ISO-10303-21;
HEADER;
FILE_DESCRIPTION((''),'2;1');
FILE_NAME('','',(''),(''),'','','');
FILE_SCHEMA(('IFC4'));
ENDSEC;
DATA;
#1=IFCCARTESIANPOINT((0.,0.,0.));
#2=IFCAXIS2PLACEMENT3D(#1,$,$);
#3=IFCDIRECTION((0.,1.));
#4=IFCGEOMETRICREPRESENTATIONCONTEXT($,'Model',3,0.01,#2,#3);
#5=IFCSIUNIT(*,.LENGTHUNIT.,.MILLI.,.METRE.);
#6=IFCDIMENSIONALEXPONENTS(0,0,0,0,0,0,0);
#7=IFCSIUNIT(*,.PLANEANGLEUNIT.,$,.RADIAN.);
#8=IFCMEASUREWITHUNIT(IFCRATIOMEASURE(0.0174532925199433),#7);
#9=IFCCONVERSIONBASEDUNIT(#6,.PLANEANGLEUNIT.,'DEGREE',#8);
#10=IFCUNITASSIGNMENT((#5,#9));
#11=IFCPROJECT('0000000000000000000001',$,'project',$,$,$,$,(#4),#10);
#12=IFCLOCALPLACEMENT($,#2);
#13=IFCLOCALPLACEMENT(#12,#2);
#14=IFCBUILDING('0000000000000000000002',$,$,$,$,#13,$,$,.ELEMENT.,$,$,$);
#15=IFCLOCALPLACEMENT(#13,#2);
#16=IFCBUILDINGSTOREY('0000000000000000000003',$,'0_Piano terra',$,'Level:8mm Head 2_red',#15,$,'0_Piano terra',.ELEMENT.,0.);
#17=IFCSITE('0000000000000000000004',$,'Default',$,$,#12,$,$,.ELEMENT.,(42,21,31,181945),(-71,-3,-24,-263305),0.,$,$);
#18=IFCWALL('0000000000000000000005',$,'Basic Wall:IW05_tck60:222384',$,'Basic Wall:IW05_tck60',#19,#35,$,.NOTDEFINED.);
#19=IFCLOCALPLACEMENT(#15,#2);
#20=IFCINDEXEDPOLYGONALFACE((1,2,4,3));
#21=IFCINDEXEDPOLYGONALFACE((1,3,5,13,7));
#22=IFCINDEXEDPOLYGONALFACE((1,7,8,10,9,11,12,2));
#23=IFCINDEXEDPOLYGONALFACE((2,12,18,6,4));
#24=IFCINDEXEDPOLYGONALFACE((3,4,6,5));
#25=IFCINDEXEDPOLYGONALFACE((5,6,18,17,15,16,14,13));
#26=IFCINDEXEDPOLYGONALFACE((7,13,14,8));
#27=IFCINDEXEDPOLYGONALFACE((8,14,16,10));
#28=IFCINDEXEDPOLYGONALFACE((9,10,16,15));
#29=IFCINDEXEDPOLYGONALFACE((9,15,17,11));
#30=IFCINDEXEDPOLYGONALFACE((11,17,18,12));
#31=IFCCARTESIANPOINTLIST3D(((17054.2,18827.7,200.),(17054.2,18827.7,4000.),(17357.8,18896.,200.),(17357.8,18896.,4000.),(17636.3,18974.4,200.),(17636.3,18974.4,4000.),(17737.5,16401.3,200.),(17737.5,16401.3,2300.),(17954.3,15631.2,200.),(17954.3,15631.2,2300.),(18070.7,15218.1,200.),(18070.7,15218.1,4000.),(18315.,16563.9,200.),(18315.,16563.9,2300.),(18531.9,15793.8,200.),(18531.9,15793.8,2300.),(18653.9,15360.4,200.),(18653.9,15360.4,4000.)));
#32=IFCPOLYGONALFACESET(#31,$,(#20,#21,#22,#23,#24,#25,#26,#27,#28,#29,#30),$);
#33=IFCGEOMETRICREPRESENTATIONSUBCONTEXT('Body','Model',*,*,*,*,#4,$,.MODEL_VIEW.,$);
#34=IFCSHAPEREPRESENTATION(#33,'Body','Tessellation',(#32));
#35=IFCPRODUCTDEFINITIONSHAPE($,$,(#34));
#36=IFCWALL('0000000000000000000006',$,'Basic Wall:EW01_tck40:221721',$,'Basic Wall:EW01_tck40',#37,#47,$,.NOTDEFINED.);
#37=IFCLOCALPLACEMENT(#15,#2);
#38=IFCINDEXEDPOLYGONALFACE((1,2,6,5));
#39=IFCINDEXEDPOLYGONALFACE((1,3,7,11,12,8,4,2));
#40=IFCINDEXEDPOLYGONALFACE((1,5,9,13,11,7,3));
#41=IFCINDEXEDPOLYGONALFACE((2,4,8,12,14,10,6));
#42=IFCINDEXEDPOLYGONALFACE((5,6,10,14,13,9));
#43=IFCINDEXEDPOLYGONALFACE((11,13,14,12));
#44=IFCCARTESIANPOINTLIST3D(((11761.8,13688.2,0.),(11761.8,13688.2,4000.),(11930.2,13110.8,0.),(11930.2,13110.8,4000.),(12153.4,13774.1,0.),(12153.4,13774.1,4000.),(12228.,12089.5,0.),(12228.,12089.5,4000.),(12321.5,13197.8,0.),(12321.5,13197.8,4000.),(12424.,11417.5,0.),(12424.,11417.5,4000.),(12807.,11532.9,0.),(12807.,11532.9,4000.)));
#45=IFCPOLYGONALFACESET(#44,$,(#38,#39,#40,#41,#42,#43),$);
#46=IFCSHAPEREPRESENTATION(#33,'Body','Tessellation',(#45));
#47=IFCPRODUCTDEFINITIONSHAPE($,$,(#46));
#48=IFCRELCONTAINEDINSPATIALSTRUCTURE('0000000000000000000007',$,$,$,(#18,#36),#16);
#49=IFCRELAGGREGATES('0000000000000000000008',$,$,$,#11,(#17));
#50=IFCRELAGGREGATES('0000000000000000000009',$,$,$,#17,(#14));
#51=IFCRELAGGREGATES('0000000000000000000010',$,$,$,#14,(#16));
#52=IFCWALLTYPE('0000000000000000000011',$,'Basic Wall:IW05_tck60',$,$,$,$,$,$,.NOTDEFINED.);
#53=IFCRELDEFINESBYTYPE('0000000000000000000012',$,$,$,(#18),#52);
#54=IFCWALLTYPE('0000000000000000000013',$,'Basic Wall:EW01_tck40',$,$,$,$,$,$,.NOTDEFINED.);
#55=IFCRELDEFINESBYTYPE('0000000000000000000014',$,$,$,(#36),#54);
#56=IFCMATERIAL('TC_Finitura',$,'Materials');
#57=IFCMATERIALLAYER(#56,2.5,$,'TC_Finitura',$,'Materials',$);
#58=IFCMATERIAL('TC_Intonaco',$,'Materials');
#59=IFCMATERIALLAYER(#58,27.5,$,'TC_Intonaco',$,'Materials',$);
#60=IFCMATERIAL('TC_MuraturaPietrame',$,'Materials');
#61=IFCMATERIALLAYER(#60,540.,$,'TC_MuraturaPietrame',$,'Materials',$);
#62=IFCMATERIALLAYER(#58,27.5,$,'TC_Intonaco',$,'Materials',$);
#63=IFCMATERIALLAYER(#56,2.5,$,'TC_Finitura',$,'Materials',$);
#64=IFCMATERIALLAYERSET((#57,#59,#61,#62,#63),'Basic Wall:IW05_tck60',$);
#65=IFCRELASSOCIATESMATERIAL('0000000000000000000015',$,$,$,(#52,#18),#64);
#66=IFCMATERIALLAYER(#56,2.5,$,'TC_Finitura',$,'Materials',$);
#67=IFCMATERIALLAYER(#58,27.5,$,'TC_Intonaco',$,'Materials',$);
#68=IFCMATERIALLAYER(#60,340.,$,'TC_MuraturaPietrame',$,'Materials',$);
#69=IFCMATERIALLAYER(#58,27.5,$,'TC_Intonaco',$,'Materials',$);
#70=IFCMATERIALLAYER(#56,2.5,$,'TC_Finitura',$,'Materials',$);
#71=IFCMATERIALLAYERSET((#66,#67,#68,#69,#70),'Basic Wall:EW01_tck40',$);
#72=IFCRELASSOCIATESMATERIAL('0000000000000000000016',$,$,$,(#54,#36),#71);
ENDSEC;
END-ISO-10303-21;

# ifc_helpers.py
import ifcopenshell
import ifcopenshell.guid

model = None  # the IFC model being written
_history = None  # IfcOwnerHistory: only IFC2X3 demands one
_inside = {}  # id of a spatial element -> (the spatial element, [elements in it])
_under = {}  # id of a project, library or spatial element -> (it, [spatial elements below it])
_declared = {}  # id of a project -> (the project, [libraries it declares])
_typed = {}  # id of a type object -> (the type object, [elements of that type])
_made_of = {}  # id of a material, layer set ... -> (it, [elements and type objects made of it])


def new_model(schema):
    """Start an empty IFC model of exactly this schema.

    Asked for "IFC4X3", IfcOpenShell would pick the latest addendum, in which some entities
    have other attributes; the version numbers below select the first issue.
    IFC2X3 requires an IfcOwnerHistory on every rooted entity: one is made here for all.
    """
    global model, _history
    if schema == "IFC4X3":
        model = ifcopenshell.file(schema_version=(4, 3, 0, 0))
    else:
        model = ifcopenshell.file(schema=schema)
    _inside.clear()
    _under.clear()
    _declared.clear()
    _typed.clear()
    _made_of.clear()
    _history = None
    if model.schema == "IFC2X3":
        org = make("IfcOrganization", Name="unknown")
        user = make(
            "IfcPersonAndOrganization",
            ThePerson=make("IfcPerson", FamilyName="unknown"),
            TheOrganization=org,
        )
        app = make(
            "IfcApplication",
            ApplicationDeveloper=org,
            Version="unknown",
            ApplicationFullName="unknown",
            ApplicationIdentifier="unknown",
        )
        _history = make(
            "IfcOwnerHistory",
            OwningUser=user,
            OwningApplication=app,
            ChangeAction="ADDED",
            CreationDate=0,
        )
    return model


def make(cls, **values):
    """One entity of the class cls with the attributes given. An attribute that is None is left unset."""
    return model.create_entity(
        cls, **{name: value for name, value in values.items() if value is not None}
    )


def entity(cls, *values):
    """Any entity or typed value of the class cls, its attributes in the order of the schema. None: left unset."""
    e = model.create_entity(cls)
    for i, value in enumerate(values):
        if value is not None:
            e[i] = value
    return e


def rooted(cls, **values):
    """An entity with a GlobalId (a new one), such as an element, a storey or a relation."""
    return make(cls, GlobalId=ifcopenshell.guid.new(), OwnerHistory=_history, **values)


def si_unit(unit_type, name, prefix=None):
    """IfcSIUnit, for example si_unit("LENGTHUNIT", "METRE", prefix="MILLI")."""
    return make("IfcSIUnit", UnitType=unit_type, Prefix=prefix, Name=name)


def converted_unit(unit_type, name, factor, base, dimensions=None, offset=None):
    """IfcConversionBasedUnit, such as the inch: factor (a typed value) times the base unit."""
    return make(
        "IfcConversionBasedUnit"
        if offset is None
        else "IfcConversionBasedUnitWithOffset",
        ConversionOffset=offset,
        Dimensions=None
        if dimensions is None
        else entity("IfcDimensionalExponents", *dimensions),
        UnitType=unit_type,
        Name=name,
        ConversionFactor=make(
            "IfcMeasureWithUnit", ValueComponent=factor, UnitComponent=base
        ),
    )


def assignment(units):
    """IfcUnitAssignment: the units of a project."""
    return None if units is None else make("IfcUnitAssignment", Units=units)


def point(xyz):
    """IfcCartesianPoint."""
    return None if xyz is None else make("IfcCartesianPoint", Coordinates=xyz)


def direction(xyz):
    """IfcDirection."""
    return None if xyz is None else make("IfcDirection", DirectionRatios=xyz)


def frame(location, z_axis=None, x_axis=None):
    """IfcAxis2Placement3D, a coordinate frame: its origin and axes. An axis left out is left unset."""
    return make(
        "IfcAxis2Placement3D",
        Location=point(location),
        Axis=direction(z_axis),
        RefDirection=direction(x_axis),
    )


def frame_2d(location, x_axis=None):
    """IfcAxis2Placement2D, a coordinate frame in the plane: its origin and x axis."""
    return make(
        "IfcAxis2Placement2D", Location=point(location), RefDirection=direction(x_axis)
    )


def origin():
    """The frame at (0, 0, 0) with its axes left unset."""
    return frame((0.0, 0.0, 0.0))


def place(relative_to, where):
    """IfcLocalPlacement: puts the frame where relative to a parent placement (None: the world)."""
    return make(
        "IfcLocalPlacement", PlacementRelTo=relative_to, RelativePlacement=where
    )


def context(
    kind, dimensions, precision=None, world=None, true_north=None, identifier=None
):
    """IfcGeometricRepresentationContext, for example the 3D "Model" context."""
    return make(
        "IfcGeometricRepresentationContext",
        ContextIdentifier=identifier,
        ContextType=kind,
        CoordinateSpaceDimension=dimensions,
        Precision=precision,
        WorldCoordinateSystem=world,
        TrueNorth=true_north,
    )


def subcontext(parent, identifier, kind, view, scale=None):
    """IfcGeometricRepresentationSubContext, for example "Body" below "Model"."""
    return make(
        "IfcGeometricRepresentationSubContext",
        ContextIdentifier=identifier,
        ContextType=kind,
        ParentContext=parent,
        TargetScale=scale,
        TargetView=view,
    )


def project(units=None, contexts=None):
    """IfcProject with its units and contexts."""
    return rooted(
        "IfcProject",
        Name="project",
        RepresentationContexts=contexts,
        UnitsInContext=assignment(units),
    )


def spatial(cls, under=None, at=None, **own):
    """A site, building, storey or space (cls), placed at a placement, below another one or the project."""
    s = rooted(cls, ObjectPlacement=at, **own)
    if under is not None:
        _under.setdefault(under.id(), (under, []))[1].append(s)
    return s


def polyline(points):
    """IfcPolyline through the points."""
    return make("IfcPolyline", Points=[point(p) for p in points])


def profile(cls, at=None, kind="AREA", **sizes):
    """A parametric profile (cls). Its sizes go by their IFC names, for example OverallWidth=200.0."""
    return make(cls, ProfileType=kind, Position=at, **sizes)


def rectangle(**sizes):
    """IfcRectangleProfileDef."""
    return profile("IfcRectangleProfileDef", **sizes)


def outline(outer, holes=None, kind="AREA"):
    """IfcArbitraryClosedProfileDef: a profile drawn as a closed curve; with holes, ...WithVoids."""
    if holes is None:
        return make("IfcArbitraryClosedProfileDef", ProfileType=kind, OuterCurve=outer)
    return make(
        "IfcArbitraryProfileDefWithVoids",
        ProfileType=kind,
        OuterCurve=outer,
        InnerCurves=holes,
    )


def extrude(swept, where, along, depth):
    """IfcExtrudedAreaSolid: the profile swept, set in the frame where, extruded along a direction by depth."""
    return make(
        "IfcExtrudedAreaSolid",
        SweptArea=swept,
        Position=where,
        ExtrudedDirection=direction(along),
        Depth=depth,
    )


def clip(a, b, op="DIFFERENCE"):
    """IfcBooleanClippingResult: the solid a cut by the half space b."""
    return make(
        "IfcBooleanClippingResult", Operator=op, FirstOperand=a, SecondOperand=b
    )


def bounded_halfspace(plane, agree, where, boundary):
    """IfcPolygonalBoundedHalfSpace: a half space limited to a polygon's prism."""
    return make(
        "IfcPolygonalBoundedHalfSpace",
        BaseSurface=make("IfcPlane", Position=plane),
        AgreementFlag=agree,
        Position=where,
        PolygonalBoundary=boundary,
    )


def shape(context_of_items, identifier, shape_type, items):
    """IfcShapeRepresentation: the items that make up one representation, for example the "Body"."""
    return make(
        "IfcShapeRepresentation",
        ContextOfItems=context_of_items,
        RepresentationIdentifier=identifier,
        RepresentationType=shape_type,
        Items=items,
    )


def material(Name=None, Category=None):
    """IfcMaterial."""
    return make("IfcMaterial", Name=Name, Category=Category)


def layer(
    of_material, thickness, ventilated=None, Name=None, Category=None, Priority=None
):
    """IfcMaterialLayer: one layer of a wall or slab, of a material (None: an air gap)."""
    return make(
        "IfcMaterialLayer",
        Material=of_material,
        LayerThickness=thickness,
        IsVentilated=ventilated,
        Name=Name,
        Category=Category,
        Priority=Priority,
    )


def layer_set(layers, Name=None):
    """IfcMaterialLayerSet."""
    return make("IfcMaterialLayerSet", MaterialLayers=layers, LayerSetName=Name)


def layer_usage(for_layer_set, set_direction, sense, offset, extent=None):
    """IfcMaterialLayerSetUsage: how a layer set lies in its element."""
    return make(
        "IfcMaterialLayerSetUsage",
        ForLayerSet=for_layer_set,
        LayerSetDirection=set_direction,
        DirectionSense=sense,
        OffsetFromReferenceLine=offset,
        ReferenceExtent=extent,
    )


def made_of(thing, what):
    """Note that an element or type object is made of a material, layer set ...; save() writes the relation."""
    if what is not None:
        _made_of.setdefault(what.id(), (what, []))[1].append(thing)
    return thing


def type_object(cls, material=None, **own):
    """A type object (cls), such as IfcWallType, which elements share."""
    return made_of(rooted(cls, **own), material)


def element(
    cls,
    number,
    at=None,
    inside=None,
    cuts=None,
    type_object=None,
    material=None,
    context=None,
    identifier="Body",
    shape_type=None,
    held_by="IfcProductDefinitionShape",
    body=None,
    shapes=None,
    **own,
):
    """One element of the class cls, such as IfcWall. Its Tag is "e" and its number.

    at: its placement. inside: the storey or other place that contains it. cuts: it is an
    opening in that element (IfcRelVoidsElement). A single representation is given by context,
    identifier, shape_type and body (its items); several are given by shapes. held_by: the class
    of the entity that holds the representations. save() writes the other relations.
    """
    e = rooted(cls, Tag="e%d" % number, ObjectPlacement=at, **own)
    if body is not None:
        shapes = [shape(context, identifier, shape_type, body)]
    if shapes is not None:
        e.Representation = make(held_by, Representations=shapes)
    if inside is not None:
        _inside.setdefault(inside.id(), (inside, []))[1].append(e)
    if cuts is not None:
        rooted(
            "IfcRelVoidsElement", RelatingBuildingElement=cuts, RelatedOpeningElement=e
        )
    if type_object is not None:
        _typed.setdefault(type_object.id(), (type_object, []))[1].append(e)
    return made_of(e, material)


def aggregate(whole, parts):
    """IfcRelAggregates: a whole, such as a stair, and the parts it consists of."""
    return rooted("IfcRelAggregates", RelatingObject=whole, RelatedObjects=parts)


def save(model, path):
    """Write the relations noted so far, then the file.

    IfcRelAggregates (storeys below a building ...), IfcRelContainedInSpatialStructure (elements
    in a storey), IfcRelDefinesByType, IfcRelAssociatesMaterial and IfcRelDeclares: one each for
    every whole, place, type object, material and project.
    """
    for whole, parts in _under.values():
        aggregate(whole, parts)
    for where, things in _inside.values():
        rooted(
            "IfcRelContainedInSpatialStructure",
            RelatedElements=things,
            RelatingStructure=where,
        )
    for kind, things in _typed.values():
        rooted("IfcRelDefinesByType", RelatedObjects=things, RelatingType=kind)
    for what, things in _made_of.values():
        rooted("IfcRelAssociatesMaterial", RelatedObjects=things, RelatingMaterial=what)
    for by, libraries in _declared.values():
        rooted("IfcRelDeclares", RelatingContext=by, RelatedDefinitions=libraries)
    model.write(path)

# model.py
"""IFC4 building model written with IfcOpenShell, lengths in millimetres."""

from ifc_helpers import new_model, entity, si_unit, converted_unit, direction, frame, frame_2d, origin, place, context, subcontext, project, spatial, polyline, rectangle, outline, extrude, clip, bounded_halfspace, material, layer, layer_set, layer_usage, type_object, element, save


model = new_model("IFC4")

# Units and contexts
model_context = context("Model", 3, precision=0.01, world=origin(), true_north=direction((0.0, 1.0)))
body_context = subcontext(model_context, "Body", "Model", "MODEL_VIEW")
ifc_project = project(units=[si_unit("LENGTHUNIT", "METRE", prefix="MILLI"), converted_unit("PLANEANGLEUNIT", "DEGREE", entity("IfcRatioMeasure", 0.0174532925199433), si_unit("PLANEANGLEUNIT", "RADIAN"), dimensions=[0, 0, 0, 0, 0, 0, 0])], contexts=[model_context])

# Site, building, storey
site_placement = place(None, origin())
site = spatial("IfcSite", under=ifc_project, at=site_placement, Name="Default", CompositionType="ELEMENT", RefLatitude=(42, 21, 31, 181945), RefLongitude=(-71, -3, -24, -263305), RefElevation=0.0)
building_placement = place(site_placement, origin())
building = spatial("IfcBuilding", under=site, at=building_placement, CompositionType="ELEMENT")
storey_placement = place(building_placement, origin())
storey = spatial("IfcBuildingStorey", under=building, at=storey_placement, Name="0_Piano terra", ObjectType="Level:8mm Head 2_red", LongName="0_Piano terra", CompositionType="ELEMENT", Elevation=0.0)

# Shared definitions
ifc_material_1 = material(Name="TC_Finitura", Category="Materials")
ifc_material_2 = material(Name="TC_Intonaco", Category="Materials")
ifc_material_3 = material(Name="TC_MuraturaPietrame", Category="Materials")

# Shared definitions
ifc_layer_1 = layer(ifc_material_1, 2.5, Name="TC_Finitura", Category="Materials")
ifc_layer_2 = layer(ifc_material_2, 27.5, Name="TC_Intonaco", Category="Materials")
ifc_layer_3 = layer(ifc_material_3, 540.0, Name="TC_MuraturaPietrame", Category="Materials")
ifc_layer_4 = layer(ifc_material_2, 27.5, Name="TC_Intonaco", Category="Materials")
ifc_layer_5 = layer(ifc_material_1, 2.5, Name="TC_Finitura", Category="Materials")
ifc_layer_set_1 = layer_set([ifc_layer_1, ifc_layer_2, ifc_layer_3, ifc_layer_4, ifc_layer_5], Name="Basic Wall:IW05_tck60")
wall_type_1 = type_object("IfcWallType", Name="Basic Wall:IW05_tck60", PredefinedType="NOTDEFINED", material=ifc_layer_set_1)

# Wall, opening
ifc_layer_usage_1 = layer_usage(ifc_layer_set_1, "AXIS2", "NEGATIVE", 300.0)
wall_1_placement = place(storey_placement, frame((17343.0, 18909.0, 200.0), z_axis=(0.0, 0.0, 1.0), x_axis=(0.271045, -0.962567, 0.0)))
wall_1 = element("IfcWall", 1, at=wall_1_placement, inside=storey, type_object=wall_type_1, material=ifc_layer_usage_1, Name="Basic Wall:IW05_tck60:222384", ObjectType="Basic Wall:IW05_tck60", PredefinedType="NOTDEFINED", context=body_context, shape_type="Clipping", body=[
    clip(extrude(outline(polyline([(0.0, -300.0), (3750.1, -300.0), (3751.9, -248.5), (3771.2, 300.0), (16.6, 300.0), (16.6, 10.7), (0.0, -300.0)])), origin(), (0.0, 0.0, 1.0), 3800.0), bounded_halfspace(frame((0.0, -300.0, 3800.0), z_axis=(0.0, 0.0, -1.0), x_axis=(0.999991, 0.004145, 0.0)), True, frame((0.0, -300.0, 3800.0)), polyline([(0.0, 0.0), (3750.1, 0.0), (3751.9, 51.5), (3771.2, 600.0), (16.6, 600.0), (16.6, 310.7), (0.0, 0.0)]))),
])
opening_1_placement = place(wall_1_placement, frame((2520.8, -300.0, 0.0)))
element("IfcOpeningElement", 2, at=opening_1_placement, cuts=wall_1, ObjectType="Opening", PredefinedType="OPENING", context=body_context, shape_type="SweptSolid", body=[
    extrude(rectangle(XDim=2100.0, YDim=800.0, at=frame_2d((1050.0, 400.0), x_axis=(1.0, 0.0))), frame((0.0, 0.0, 0.0), z_axis=(0.0, 1.0, 0.0), x_axis=(0.0, 0.0, 1.0)), (0.0, 0.0, 1.0), 600.0),
])

# Wall
ifc_layer_6 = layer(ifc_material_1, 2.5, Name="TC_Finitura", Category="Materials")
ifc_layer_7 = layer(ifc_material_2, 27.5, Name="TC_Intonaco", Category="Materials")
ifc_layer_8 = layer(ifc_material_3, 340.0, Name="TC_MuraturaPietrame", Category="Materials")
ifc_layer_9 = layer(ifc_material_2, 27.5, Name="TC_Intonaco", Category="Materials")
ifc_layer_10 = layer(ifc_material_1, 2.5, Name="TC_Finitura", Category="Materials")
ifc_layer_set_2 = layer_set([ifc_layer_6, ifc_layer_7, ifc_layer_8, ifc_layer_9, ifc_layer_10], Name="Basic Wall:EW01_tck40")
ifc_layer_usage_2 = layer_usage(ifc_layer_set_2, "AXIS2", "NEGATIVE", 200.0)
wall_type_2 = type_object("IfcWallType", Name="Basic Wall:EW01_tck40", PredefinedType="NOTDEFINED", material=ifc_layer_set_2)
wall_2_placement = place(storey_placement, frame((11953.8, 13744.2, 0.0), z_axis=(0.0, 0.0, 1.0), x_axis=(0.279974, -0.960008, 0.0)))
element("IfcWall", 3, at=wall_2_placement, inside=storey, type_object=wall_type_2, material=ifc_layer_usage_2, Name="Basic Wall:EW01_tck40:221721", ObjectType="Basic Wall:EW01_tck40", PredefinedType="NOTDEFINED", context=body_context, shape_type="SweptSolid", body=[
    extrude(outline(polyline([(2365.3, -200.0), (2361.7, 200.0), (627.5, 200.0), (27.1, 200.0), (0.0, -200.0), (601.4, -200.0), (1665.3, -200.0), (2365.3, -200.0)])), origin(), (0.0, 0.0, 1.0), 4000.0),
])

save(model, "model.ifc")
